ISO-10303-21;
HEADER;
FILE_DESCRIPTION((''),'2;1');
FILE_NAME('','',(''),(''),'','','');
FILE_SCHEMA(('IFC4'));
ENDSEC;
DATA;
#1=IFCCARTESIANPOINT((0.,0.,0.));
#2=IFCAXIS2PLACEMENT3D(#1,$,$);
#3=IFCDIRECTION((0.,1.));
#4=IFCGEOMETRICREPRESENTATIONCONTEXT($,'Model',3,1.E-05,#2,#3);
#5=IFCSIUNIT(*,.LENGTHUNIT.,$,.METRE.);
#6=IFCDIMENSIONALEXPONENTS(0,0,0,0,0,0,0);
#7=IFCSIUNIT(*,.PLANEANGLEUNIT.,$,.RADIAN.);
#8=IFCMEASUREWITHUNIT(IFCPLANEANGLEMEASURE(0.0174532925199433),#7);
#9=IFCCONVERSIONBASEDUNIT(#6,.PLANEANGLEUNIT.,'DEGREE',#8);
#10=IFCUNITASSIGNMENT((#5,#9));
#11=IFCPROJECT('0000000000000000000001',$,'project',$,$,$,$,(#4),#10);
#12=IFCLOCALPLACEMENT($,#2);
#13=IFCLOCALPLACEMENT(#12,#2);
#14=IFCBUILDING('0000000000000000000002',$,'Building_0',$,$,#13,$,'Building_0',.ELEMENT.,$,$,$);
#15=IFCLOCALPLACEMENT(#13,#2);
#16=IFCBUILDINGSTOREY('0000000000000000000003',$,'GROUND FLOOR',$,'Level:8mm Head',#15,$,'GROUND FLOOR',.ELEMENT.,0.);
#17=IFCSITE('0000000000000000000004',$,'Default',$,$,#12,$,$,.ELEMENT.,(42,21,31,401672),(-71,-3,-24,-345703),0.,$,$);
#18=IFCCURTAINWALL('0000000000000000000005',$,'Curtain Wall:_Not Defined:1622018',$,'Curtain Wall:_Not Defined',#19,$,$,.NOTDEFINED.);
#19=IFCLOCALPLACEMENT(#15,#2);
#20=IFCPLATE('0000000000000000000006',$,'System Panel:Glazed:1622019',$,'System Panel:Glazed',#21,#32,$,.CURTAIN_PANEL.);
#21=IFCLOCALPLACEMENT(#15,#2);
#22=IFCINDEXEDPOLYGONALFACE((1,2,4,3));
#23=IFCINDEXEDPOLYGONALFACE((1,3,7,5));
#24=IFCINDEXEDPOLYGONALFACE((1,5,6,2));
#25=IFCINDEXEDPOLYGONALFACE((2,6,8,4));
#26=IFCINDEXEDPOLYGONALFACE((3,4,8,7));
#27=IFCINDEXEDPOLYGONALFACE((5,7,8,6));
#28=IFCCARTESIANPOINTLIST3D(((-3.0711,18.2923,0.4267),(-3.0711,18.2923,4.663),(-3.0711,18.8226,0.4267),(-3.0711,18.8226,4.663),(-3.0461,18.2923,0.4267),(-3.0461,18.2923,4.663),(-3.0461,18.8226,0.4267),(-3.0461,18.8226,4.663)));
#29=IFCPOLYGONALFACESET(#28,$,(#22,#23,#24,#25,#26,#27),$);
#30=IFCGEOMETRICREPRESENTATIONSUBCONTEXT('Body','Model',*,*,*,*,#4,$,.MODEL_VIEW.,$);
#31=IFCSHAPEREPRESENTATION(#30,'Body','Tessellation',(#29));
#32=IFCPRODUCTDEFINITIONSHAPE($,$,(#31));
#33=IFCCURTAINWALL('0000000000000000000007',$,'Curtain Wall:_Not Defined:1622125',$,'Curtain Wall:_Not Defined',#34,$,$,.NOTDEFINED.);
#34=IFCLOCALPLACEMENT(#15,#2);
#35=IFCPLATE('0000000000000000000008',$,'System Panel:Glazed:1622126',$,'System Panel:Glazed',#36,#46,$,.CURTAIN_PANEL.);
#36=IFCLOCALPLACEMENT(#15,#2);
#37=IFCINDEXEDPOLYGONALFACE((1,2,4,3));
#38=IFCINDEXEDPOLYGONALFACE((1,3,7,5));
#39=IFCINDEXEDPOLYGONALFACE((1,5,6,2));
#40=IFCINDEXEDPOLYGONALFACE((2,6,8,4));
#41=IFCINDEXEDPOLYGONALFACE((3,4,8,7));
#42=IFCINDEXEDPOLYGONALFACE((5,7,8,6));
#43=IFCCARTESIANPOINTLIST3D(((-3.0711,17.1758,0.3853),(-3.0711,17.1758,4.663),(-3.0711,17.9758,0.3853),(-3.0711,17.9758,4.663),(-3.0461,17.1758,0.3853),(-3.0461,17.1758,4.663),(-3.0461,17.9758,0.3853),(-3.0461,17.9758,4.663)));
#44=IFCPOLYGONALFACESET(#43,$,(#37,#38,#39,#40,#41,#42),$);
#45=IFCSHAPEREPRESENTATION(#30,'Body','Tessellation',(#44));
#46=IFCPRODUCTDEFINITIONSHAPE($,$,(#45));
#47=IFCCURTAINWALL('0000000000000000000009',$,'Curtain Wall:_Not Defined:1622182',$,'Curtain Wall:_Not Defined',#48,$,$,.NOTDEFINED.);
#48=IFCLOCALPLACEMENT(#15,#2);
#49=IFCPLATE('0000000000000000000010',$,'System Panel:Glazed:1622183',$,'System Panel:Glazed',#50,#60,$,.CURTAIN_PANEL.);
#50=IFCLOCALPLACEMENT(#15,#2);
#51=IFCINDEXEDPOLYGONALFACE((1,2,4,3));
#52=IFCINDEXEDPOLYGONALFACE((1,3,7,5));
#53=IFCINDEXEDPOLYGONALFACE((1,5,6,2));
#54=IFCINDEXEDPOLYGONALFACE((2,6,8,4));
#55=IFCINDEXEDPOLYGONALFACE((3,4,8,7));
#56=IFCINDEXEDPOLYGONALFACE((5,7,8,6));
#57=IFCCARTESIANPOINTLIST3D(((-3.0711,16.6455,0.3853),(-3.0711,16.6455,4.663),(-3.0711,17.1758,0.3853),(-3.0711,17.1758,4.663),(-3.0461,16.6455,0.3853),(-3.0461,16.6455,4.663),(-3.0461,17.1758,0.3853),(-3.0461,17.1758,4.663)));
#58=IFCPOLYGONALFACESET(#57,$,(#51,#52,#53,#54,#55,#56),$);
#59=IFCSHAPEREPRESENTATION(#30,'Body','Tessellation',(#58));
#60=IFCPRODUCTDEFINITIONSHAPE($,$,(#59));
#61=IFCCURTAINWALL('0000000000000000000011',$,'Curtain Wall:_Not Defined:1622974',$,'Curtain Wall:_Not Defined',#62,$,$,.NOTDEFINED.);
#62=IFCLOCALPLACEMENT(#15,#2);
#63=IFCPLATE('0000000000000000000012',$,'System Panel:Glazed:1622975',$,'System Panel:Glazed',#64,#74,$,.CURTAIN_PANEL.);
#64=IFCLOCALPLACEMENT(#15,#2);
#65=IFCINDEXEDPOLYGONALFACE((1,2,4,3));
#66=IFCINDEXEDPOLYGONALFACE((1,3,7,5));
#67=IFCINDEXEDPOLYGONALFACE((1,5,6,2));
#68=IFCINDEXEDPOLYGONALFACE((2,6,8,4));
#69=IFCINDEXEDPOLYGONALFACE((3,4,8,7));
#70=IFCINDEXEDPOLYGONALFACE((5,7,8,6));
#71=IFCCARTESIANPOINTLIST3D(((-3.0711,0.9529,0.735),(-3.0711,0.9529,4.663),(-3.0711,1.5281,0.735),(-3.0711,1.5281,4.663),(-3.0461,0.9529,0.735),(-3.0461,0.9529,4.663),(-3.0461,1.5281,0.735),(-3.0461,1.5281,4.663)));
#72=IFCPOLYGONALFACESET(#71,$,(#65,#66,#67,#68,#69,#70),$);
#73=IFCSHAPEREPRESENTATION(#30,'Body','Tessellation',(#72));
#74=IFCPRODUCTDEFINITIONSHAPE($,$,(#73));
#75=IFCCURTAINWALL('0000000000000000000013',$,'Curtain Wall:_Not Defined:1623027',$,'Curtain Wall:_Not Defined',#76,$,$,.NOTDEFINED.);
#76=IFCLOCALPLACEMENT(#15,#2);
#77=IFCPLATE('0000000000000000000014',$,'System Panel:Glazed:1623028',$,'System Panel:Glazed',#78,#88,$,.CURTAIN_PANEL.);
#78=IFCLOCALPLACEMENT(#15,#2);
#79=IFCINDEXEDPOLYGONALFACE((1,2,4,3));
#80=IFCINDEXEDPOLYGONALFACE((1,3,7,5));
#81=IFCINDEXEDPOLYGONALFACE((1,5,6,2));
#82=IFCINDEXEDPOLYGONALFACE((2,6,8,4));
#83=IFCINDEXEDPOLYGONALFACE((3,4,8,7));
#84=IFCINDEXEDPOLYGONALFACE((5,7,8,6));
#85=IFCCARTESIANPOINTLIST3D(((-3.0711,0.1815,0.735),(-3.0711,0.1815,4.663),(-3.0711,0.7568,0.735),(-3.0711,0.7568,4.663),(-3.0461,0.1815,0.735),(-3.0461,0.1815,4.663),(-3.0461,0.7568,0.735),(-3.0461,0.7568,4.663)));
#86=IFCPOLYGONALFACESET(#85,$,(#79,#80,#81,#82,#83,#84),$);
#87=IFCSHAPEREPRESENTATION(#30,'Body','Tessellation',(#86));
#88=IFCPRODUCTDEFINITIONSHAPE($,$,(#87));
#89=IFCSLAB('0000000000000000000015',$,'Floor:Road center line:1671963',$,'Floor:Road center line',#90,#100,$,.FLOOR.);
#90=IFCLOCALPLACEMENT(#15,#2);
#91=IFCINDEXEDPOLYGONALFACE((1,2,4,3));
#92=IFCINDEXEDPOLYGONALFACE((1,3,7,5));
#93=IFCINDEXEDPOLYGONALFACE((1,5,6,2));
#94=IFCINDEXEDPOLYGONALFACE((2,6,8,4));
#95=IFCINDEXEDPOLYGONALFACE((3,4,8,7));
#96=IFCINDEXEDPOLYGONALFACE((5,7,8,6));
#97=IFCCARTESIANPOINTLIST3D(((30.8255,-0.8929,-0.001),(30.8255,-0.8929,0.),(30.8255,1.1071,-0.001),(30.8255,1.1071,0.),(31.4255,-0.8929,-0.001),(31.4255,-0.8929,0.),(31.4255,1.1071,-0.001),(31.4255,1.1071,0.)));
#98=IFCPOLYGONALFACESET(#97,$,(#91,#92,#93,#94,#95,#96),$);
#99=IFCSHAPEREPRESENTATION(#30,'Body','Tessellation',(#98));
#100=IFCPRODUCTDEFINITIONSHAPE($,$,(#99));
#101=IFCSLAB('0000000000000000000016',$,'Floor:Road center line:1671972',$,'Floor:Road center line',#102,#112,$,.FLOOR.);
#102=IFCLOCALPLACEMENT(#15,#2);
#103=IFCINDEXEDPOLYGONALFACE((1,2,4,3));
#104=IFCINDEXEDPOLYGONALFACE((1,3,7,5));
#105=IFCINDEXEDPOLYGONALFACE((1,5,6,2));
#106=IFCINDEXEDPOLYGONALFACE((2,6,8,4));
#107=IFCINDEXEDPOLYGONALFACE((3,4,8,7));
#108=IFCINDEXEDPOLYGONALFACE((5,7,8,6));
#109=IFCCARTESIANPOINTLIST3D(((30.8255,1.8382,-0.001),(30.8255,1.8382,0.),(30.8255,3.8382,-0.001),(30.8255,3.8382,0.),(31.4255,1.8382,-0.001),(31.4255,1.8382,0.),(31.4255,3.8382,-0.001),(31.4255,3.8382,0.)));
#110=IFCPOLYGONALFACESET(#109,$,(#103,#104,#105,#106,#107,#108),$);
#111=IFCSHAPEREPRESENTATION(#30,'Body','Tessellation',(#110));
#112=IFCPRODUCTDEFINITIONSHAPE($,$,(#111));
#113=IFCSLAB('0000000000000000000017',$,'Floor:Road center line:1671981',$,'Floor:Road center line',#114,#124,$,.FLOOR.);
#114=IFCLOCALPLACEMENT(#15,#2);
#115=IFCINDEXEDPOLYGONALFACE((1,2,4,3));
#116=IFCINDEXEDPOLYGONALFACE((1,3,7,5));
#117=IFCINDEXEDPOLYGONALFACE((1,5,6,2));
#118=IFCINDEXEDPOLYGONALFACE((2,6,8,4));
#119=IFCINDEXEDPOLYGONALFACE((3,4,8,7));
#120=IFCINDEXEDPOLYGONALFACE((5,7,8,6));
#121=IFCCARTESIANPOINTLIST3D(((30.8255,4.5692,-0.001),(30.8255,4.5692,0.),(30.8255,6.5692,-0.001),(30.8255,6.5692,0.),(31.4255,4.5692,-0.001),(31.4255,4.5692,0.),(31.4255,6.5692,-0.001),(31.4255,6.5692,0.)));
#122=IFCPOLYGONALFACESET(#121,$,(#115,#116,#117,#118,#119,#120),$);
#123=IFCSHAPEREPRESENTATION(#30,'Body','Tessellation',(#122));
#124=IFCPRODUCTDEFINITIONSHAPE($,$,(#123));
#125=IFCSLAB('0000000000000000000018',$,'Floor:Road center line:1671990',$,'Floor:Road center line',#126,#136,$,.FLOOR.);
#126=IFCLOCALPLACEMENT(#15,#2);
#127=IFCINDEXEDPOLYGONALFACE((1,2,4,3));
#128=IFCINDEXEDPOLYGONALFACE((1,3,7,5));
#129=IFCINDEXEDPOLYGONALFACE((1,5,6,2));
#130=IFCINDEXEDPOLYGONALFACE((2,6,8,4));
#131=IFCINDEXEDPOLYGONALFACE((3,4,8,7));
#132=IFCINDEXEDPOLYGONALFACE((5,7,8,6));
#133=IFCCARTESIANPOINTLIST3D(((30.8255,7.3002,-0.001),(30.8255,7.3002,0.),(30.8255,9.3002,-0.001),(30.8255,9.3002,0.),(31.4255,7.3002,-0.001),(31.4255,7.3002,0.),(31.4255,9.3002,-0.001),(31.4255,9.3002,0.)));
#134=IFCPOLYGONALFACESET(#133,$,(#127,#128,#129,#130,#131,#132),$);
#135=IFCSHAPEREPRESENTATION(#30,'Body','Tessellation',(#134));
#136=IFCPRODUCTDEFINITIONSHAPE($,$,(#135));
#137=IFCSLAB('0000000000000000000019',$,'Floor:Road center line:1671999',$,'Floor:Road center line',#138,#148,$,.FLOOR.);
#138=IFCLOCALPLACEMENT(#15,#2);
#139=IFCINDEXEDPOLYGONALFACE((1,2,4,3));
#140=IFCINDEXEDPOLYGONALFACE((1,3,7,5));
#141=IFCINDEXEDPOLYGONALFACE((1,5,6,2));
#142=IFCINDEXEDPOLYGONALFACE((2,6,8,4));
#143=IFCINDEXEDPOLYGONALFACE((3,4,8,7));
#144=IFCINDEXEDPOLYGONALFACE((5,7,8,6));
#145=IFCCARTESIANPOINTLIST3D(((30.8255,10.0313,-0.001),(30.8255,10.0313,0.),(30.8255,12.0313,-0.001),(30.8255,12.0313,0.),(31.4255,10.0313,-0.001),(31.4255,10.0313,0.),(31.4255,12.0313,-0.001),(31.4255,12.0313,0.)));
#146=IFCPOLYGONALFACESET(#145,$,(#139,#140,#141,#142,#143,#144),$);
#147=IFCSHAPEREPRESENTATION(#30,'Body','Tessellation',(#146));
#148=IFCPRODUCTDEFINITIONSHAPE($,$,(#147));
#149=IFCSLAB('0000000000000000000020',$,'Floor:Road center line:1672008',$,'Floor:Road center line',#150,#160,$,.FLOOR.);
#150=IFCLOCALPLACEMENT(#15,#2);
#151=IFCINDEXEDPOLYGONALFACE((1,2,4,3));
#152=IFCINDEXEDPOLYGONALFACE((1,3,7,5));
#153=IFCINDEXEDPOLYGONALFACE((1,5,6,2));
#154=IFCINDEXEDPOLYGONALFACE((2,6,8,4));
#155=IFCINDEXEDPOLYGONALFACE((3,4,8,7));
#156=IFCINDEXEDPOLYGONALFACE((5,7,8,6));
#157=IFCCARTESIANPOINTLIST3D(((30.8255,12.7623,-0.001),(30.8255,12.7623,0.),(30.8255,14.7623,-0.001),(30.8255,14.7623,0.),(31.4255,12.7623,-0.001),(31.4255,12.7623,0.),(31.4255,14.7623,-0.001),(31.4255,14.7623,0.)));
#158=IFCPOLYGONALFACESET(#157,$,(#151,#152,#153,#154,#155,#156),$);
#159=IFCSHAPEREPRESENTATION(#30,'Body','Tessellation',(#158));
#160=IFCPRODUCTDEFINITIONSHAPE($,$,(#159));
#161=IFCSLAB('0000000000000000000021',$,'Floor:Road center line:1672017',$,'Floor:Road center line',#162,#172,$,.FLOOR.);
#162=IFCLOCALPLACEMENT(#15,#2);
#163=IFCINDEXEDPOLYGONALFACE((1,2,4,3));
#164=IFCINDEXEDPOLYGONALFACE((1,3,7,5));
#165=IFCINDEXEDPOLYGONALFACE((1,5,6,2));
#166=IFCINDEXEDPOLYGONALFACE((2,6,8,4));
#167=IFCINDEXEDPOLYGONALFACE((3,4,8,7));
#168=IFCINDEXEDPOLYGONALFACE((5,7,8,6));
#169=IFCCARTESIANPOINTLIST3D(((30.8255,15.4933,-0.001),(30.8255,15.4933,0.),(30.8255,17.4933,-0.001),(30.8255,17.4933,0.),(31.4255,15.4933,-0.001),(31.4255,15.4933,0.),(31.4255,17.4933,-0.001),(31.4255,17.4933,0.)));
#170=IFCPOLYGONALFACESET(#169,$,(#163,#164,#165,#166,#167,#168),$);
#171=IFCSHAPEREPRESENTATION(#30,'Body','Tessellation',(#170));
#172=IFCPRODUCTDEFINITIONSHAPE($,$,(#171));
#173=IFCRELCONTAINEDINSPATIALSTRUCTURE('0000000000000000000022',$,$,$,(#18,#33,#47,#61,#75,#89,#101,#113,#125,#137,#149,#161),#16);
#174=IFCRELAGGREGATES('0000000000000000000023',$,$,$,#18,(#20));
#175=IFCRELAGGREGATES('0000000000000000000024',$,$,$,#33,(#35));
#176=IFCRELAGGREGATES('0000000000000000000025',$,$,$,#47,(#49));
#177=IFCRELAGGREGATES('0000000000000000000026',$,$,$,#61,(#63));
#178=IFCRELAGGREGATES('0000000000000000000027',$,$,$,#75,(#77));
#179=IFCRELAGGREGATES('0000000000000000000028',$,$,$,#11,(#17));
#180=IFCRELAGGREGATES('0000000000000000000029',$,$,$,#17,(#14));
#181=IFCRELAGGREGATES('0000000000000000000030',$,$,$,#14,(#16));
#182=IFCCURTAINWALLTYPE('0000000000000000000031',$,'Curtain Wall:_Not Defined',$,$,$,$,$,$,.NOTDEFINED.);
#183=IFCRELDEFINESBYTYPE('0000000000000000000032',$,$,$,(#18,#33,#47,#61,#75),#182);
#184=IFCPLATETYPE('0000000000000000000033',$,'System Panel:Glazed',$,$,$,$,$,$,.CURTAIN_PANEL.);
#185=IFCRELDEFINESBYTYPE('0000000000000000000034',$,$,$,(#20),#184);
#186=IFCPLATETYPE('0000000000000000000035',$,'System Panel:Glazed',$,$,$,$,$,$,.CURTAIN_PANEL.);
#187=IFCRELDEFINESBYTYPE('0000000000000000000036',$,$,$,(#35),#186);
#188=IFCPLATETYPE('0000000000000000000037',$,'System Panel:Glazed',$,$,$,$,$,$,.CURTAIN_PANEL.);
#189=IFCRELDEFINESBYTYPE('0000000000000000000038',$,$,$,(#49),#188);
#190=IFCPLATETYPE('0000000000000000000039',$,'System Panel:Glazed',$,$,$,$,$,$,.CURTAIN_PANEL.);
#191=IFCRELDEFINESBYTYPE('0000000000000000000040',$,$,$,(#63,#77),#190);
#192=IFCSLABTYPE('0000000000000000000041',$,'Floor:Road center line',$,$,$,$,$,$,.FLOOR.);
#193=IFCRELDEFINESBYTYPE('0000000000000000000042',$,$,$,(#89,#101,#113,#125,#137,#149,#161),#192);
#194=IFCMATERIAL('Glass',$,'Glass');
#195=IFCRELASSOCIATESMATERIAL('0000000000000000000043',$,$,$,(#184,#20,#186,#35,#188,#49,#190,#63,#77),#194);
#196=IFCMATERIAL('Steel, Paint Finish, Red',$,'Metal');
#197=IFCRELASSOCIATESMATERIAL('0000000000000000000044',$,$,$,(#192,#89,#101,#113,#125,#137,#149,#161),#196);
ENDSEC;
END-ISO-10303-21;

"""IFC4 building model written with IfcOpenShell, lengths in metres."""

from ifc_helpers import new_model, entity, si_unit, converted_unit, direction, frame, origin, place, context, subcontext, project, spatial, indexed_curve, outline, extrude, source, transform, mapped, material, type_object, type_shapes, element, aggregate, save


model = new_model("IFC4")

# Units and contexts
model_context = context("Model", 3, precision=1e-05, world=origin(), true_north=direction((0.0, 1.0)))
body_context = subcontext(model_context, "Body", "Model", "MODEL_VIEW")
ifc_project = project(units=[si_unit("LENGTHUNIT", "METRE"), converted_unit("PLANEANGLEUNIT", "DEGREE", entity("IfcPlaneAngleMeasure", 0.0174532925199433), si_unit("PLANEANGLEUNIT", "RADIAN"), dimensions=[0, 0, 0, 0, 0, 0, 0])], contexts=[model_context])

# Site, building, storey
site_placement = place(None, origin())
site = spatial("IfcSite", under=ifc_project, at=site_placement, Name="Default", CompositionType="ELEMENT", RefLatitude=(42, 21, 31, 401672), RefLongitude=(-71, -3, -24, -345703), RefElevation=0.0)
building_placement = place(site_placement, origin())
building = spatial("IfcBuilding", under=site, at=building_placement, Name="Building_0", LongName="Building_0", CompositionType="ELEMENT")
storey_placement = place(building_placement, origin())
storey = spatial("IfcBuildingStorey", under=building, at=storey_placement, Name="GROUND FLOOR", ObjectType="Level:8mm Head", LongName="GROUND FLOOR", CompositionType="ELEMENT", Elevation=0.0)

# Curtain walls, plates
curtain_wall_type = type_object("IfcCurtainWallType", Name="Curtain Wall:_Not Defined", PredefinedType="NOTDEFINED")
curtain_wall_1_placement = place(storey_placement, origin())
curtain_wall_1 = element("IfcCurtainWall", 1, at=curtain_wall_1_placement, inside=storey, type_object=curtain_wall_type, Name="Curtain Wall:_Not Defined:1622018", ObjectType="Curtain Wall:_Not Defined", PredefinedType="NOTDEFINED")
ifc_material_1 = material(Name="Glass", Category="Glass")
plate_type_1 = type_object("IfcPlateType", Name="System Panel:Glazed", PredefinedType="CURTAIN_PANEL", material=ifc_material_1)
shared_shape_1 = source(origin(), body_context, "Body", "SweptSolid", [
    extrude(outline(indexed_curve([(-0.0125, -0.2652), (0.0125, -0.2652), (0.0125, 0.2652), (-0.0125, 0.2652), (-0.0125, -0.2652)], self_intersect=False)), frame((0.0, 0.037, 0.0), z_axis=(0.0, 0.0, 1.0), x_axis=(0.0, 1.0, 0.0)), (0.0, 0.0, 1.0), 4.2363),
])
type_shapes(plate_type_1, [shared_shape_1])
plate_1_placement = place(curtain_wall_1_placement, frame((-3.0956, 18.5574, 0.4267), z_axis=(0.0, 0.0, 1.0), x_axis=(0.0, -1.0, 0.0)))
plate_1 = element("IfcPlate", 2, at=plate_1_placement, type_object=plate_type_1, material=ifc_material_1, Name="System Panel:Glazed:1622019", ObjectType="System Panel:Glazed", PredefinedType="CURTAIN_PANEL", context=body_context, shape_type="MappedRepresentation", body=[
    mapped(shared_shape_1, transform((0.0, 0.0, 0.0), scale=1.0)),
])
aggregate(curtain_wall_1, [plate_1])
curtain_wall_2_placement = place(storey_placement, origin())
curtain_wall_2 = element("IfcCurtainWall", 3, at=curtain_wall_2_placement, inside=storey, type_object=curtain_wall_type, Name="Curtain Wall:_Not Defined:1622125", ObjectType="Curtain Wall:_Not Defined", PredefinedType="NOTDEFINED")
plate_type_2 = type_object("IfcPlateType", Name="System Panel:Glazed", PredefinedType="CURTAIN_PANEL", material=ifc_material_1)
shared_shape_2 = source(origin(), body_context, "Body", "SweptSolid", [
    extrude(outline(indexed_curve([(-0.0125, -0.4), (0.0125, -0.4), (0.0125, 0.4), (-0.0125, 0.4), (-0.0125, -0.4)], self_intersect=False)), frame((0.0, 0.037, 0.0), z_axis=(0.0, 0.0, 1.0), x_axis=(0.0, 1.0, 0.0)), (0.0, 0.0, 1.0), 4.2777),
])
type_shapes(plate_type_2, [shared_shape_2])
plate_2_placement = place(curtain_wall_2_placement, frame((-3.0956, 17.5758, 0.3853), z_axis=(0.0, 0.0, 1.0), x_axis=(0.0, -1.0, 0.0)))
plate_2 = element("IfcPlate", 4, at=plate_2_placement, type_object=plate_type_2, material=ifc_material_1, Name="System Panel:Glazed:1622126", ObjectType="System Panel:Glazed", PredefinedType="CURTAIN_PANEL", context=body_context, shape_type="MappedRepresentation", body=[
    mapped(shared_shape_2, transform((0.0, 0.0, 0.0), scale=1.0)),
])
aggregate(curtain_wall_2, [plate_2])
curtain_wall_3_placement = place(storey_placement, origin())
curtain_wall_3 = element("IfcCurtainWall", 5, at=curtain_wall_3_placement, inside=storey, type_object=curtain_wall_type, Name="Curtain Wall:_Not Defined:1622182", ObjectType="Curtain Wall:_Not Defined", PredefinedType="NOTDEFINED")
plate_type_3 = type_object("IfcPlateType", Name="System Panel:Glazed", PredefinedType="CURTAIN_PANEL", material=ifc_material_1)
shared_shape_3 = source(origin(), body_context, "Body", "SweptSolid", [
    extrude(outline(indexed_curve([(-0.0125, -0.2652), (0.0125, -0.2652), (0.0125, 0.2652), (-0.0125, 0.2652), (-0.0125, -0.2652)], self_intersect=False)), frame((0.0, 0.037, 0.0), z_axis=(0.0, 0.0, 1.0), x_axis=(0.0, 1.0, 0.0)), (0.0, 0.0, 1.0), 4.2777),
])
type_shapes(plate_type_3, [shared_shape_3])
plate_3_placement = place(curtain_wall_3_placement, frame((-3.0956, 16.9107, 0.3853), z_axis=(0.0, 0.0, 1.0), x_axis=(0.0, -1.0, 0.0)))
plate_3 = element("IfcPlate", 6, at=plate_3_placement, type_object=plate_type_3, material=ifc_material_1, Name="System Panel:Glazed:1622183", ObjectType="System Panel:Glazed", PredefinedType="CURTAIN_PANEL", context=body_context, shape_type="MappedRepresentation", body=[
    mapped(shared_shape_3, transform((0.0, 0.0, 0.0), scale=1.0)),
])
aggregate(curtain_wall_3, [plate_3])
curtain_wall_4_placement = place(storey_placement, origin())
curtain_wall_4 = element("IfcCurtainWall", 7, at=curtain_wall_4_placement, inside=storey, type_object=curtain_wall_type, Name="Curtain Wall:_Not Defined:1622974", ObjectType="Curtain Wall:_Not Defined", PredefinedType="NOTDEFINED")
plate_type_4 = type_object("IfcPlateType", Name="System Panel:Glazed", PredefinedType="CURTAIN_PANEL", material=ifc_material_1)
shared_shape_4 = source(origin(), body_context, "Body", "SweptSolid", [
    extrude(outline(indexed_curve([(-0.0125, -0.2876), (0.0125, -0.2876), (0.0125, 0.2876), (-0.0125, 0.2876), (-0.0125, -0.2876)], self_intersect=False)), frame((0.0, 0.037, 0.0), z_axis=(0.0, 0.0, 1.0), x_axis=(0.0, 1.0, 0.0)), (0.0, 0.0, 1.0), 3.928),
])
type_shapes(plate_type_4, [shared_shape_4])
plate_4_placement = place(curtain_wall_4_placement, frame((-3.0956, 1.2405, 0.735), z_axis=(0.0, 0.0, 1.0), x_axis=(0.0, -1.0, 0.0)))
plate_4 = element("IfcPlate", 8, at=plate_4_placement, type_object=plate_type_4, material=ifc_material_1, Name="System Panel:Glazed:1622975", ObjectType="System Panel:Glazed", PredefinedType="CURTAIN_PANEL", context=body_context, shape_type="MappedRepresentation", body=[
    mapped(shared_shape_4, transform((0.0, 0.0, 0.0), scale=1.0)),
])
aggregate(curtain_wall_4, [plate_4])
curtain_wall_5_placement = place(storey_placement, origin())
curtain_wall_5 = element("IfcCurtainWall", 9, at=curtain_wall_5_placement, inside=storey, type_object=curtain_wall_type, Name="Curtain Wall:_Not Defined:1623027", ObjectType="Curtain Wall:_Not Defined", PredefinedType="NOTDEFINED")
plate_5_placement = place(curtain_wall_5_placement, frame((-3.0956, 0.4691, 0.735), z_axis=(0.0, 0.0, 1.0), x_axis=(0.0, -1.0, 0.0)))
plate_5 = element("IfcPlate", 10, at=plate_5_placement, type_object=plate_type_4, material=ifc_material_1, Name="System Panel:Glazed:1623028", ObjectType="System Panel:Glazed", PredefinedType="CURTAIN_PANEL", context=body_context, shape_type="MappedRepresentation", body=[
    mapped(shared_shape_4, transform((0.0, 0.0, 0.0), scale=1.0)),
])
aggregate(curtain_wall_5, [plate_5])

# Slabs
ifc_material_2 = material(Name="Steel, Paint Finish, Red", Category="Metal")
slab_type = type_object("IfcSlabType", Name="Floor:Road center line", PredefinedType="FLOOR", material=ifc_material_2)
slab_1_placement = place(storey_placement, origin())
element("IfcSlab", 11, at=slab_1_placement, inside=storey, type_object=slab_type, material=ifc_material_2, Name="Floor:Road center line:1671963", ObjectType="Floor:Road center line", PredefinedType="FLOOR", context=body_context, shape_type="SweptSolid", body=[
    extrude(outline(indexed_curve([(-1.0, -0.3), (1.0, -0.3), (1.0, 0.3), (-1.0, 0.3), (-1.0, -0.3)], self_intersect=False)), frame((31.1255, 0.1071, 0.0), z_axis=(0.0, 0.0, -1.0), x_axis=(0.0, 1.0, 0.0)), (0.0, 0.0, 1.0), 0.001),
])
slab_2_placement = place(storey_placement, origin())
element("IfcSlab", 12, at=slab_2_placement, inside=storey, type_object=slab_type, material=ifc_material_2, Name="Floor:Road center line:1671972", ObjectType="Floor:Road center line", PredefinedType="FLOOR", context=body_context, shape_type="SweptSolid", body=[
    extrude(outline(indexed_curve([(-1.0, -0.3), (1.0, -0.3), (1.0, 0.3), (-1.0, 0.3), (-1.0, -0.3)], self_intersect=False)), frame((31.1255, 2.8382, 0.0), z_axis=(0.0, 0.0, -1.0), x_axis=(0.0, 1.0, 0.0)), (0.0, 0.0, 1.0), 0.001),
])
slab_3_placement = place(storey_placement, origin())
element("IfcSlab", 13, at=slab_3_placement, inside=storey, type_object=slab_type, material=ifc_material_2, Name="Floor:Road center line:1671981", ObjectType="Floor:Road center line", PredefinedType="FLOOR", context=body_context, shape_type="SweptSolid", body=[
    extrude(outline(indexed_curve([(-1.0, -0.3), (1.0, -0.3), (1.0, 0.3), (-1.0, 0.3), (-1.0, -0.3)], self_intersect=False)), frame((31.1255, 5.5692, 0.0), z_axis=(0.0, 0.0, -1.0), x_axis=(0.0, 1.0, 0.0)), (0.0, 0.0, 1.0), 0.001),
])
slab_4_placement = place(storey_placement, origin())
element("IfcSlab", 14, at=slab_4_placement, inside=storey, type_object=slab_type, material=ifc_material_2, Name="Floor:Road center line:1671990", ObjectType="Floor:Road center line", PredefinedType="FLOOR", context=body_context, shape_type="SweptSolid", body=[
    extrude(outline(indexed_curve([(-1.0, -0.3), (1.0, -0.3), (1.0, 0.3), (-1.0, 0.3), (-1.0, -0.3)], self_intersect=False)), frame((31.1255, 8.3002, 0.0), z_axis=(0.0, 0.0, -1.0), x_axis=(0.0, 1.0, 0.0)), (0.0, 0.0, 1.0), 0.001),
])
slab_5_placement = place(storey_placement, origin())
element("IfcSlab", 15, at=slab_5_placement, inside=storey, type_object=slab_type, material=ifc_material_2, Name="Floor:Road center line:1671999", ObjectType="Floor:Road center line", PredefinedType="FLOOR", context=body_context, shape_type="SweptSolid", body=[
    extrude(outline(indexed_curve([(-1.0, -0.3), (1.0, -0.3), (1.0, 0.3), (-1.0, 0.3), (-1.0, -0.3)], self_intersect=False)), frame((31.1255, 11.0313, 0.0), z_axis=(0.0, 0.0, -1.0), x_axis=(0.0, 1.0, 0.0)), (0.0, 0.0, 1.0), 0.001),
])
slab_6_placement = place(storey_placement, origin())
element("IfcSlab", 16, at=slab_6_placement, inside=storey, type_object=slab_type, material=ifc_material_2, Name="Floor:Road center line:1672008", ObjectType="Floor:Road center line", PredefinedType="FLOOR", context=body_context, shape_type="SweptSolid", body=[
    extrude(outline(indexed_curve([(-1.0, -0.3), (1.0, -0.3), (1.0, 0.3), (-1.0, 0.3), (-1.0, -0.3)], self_intersect=False)), frame((31.1255, 13.7623, 0.0), z_axis=(0.0, 0.0, -1.0), x_axis=(0.0, 1.0, 0.0)), (0.0, 0.0, 1.0), 0.001),
])
slab_7_placement = place(storey_placement, origin())
element("IfcSlab", 17, at=slab_7_placement, inside=storey, type_object=slab_type, material=ifc_material_2, Name="Floor:Road center line:1672017", ObjectType="Floor:Road center line", PredefinedType="FLOOR", context=body_context, shape_type="SweptSolid", body=[
    extrude(outline(indexed_curve([(-1.0, -0.3), (1.0, -0.3), (1.0, 0.3), (-1.0, 0.3), (-1.0, -0.3)], self_intersect=False)), frame((31.1255, 16.4933, 0.0), z_axis=(0.0, 0.0, -1.0), x_axis=(0.0, 1.0, 0.0)), (0.0, 0.0, 1.0), 0.001),
])

save(model, "model.ifc")
